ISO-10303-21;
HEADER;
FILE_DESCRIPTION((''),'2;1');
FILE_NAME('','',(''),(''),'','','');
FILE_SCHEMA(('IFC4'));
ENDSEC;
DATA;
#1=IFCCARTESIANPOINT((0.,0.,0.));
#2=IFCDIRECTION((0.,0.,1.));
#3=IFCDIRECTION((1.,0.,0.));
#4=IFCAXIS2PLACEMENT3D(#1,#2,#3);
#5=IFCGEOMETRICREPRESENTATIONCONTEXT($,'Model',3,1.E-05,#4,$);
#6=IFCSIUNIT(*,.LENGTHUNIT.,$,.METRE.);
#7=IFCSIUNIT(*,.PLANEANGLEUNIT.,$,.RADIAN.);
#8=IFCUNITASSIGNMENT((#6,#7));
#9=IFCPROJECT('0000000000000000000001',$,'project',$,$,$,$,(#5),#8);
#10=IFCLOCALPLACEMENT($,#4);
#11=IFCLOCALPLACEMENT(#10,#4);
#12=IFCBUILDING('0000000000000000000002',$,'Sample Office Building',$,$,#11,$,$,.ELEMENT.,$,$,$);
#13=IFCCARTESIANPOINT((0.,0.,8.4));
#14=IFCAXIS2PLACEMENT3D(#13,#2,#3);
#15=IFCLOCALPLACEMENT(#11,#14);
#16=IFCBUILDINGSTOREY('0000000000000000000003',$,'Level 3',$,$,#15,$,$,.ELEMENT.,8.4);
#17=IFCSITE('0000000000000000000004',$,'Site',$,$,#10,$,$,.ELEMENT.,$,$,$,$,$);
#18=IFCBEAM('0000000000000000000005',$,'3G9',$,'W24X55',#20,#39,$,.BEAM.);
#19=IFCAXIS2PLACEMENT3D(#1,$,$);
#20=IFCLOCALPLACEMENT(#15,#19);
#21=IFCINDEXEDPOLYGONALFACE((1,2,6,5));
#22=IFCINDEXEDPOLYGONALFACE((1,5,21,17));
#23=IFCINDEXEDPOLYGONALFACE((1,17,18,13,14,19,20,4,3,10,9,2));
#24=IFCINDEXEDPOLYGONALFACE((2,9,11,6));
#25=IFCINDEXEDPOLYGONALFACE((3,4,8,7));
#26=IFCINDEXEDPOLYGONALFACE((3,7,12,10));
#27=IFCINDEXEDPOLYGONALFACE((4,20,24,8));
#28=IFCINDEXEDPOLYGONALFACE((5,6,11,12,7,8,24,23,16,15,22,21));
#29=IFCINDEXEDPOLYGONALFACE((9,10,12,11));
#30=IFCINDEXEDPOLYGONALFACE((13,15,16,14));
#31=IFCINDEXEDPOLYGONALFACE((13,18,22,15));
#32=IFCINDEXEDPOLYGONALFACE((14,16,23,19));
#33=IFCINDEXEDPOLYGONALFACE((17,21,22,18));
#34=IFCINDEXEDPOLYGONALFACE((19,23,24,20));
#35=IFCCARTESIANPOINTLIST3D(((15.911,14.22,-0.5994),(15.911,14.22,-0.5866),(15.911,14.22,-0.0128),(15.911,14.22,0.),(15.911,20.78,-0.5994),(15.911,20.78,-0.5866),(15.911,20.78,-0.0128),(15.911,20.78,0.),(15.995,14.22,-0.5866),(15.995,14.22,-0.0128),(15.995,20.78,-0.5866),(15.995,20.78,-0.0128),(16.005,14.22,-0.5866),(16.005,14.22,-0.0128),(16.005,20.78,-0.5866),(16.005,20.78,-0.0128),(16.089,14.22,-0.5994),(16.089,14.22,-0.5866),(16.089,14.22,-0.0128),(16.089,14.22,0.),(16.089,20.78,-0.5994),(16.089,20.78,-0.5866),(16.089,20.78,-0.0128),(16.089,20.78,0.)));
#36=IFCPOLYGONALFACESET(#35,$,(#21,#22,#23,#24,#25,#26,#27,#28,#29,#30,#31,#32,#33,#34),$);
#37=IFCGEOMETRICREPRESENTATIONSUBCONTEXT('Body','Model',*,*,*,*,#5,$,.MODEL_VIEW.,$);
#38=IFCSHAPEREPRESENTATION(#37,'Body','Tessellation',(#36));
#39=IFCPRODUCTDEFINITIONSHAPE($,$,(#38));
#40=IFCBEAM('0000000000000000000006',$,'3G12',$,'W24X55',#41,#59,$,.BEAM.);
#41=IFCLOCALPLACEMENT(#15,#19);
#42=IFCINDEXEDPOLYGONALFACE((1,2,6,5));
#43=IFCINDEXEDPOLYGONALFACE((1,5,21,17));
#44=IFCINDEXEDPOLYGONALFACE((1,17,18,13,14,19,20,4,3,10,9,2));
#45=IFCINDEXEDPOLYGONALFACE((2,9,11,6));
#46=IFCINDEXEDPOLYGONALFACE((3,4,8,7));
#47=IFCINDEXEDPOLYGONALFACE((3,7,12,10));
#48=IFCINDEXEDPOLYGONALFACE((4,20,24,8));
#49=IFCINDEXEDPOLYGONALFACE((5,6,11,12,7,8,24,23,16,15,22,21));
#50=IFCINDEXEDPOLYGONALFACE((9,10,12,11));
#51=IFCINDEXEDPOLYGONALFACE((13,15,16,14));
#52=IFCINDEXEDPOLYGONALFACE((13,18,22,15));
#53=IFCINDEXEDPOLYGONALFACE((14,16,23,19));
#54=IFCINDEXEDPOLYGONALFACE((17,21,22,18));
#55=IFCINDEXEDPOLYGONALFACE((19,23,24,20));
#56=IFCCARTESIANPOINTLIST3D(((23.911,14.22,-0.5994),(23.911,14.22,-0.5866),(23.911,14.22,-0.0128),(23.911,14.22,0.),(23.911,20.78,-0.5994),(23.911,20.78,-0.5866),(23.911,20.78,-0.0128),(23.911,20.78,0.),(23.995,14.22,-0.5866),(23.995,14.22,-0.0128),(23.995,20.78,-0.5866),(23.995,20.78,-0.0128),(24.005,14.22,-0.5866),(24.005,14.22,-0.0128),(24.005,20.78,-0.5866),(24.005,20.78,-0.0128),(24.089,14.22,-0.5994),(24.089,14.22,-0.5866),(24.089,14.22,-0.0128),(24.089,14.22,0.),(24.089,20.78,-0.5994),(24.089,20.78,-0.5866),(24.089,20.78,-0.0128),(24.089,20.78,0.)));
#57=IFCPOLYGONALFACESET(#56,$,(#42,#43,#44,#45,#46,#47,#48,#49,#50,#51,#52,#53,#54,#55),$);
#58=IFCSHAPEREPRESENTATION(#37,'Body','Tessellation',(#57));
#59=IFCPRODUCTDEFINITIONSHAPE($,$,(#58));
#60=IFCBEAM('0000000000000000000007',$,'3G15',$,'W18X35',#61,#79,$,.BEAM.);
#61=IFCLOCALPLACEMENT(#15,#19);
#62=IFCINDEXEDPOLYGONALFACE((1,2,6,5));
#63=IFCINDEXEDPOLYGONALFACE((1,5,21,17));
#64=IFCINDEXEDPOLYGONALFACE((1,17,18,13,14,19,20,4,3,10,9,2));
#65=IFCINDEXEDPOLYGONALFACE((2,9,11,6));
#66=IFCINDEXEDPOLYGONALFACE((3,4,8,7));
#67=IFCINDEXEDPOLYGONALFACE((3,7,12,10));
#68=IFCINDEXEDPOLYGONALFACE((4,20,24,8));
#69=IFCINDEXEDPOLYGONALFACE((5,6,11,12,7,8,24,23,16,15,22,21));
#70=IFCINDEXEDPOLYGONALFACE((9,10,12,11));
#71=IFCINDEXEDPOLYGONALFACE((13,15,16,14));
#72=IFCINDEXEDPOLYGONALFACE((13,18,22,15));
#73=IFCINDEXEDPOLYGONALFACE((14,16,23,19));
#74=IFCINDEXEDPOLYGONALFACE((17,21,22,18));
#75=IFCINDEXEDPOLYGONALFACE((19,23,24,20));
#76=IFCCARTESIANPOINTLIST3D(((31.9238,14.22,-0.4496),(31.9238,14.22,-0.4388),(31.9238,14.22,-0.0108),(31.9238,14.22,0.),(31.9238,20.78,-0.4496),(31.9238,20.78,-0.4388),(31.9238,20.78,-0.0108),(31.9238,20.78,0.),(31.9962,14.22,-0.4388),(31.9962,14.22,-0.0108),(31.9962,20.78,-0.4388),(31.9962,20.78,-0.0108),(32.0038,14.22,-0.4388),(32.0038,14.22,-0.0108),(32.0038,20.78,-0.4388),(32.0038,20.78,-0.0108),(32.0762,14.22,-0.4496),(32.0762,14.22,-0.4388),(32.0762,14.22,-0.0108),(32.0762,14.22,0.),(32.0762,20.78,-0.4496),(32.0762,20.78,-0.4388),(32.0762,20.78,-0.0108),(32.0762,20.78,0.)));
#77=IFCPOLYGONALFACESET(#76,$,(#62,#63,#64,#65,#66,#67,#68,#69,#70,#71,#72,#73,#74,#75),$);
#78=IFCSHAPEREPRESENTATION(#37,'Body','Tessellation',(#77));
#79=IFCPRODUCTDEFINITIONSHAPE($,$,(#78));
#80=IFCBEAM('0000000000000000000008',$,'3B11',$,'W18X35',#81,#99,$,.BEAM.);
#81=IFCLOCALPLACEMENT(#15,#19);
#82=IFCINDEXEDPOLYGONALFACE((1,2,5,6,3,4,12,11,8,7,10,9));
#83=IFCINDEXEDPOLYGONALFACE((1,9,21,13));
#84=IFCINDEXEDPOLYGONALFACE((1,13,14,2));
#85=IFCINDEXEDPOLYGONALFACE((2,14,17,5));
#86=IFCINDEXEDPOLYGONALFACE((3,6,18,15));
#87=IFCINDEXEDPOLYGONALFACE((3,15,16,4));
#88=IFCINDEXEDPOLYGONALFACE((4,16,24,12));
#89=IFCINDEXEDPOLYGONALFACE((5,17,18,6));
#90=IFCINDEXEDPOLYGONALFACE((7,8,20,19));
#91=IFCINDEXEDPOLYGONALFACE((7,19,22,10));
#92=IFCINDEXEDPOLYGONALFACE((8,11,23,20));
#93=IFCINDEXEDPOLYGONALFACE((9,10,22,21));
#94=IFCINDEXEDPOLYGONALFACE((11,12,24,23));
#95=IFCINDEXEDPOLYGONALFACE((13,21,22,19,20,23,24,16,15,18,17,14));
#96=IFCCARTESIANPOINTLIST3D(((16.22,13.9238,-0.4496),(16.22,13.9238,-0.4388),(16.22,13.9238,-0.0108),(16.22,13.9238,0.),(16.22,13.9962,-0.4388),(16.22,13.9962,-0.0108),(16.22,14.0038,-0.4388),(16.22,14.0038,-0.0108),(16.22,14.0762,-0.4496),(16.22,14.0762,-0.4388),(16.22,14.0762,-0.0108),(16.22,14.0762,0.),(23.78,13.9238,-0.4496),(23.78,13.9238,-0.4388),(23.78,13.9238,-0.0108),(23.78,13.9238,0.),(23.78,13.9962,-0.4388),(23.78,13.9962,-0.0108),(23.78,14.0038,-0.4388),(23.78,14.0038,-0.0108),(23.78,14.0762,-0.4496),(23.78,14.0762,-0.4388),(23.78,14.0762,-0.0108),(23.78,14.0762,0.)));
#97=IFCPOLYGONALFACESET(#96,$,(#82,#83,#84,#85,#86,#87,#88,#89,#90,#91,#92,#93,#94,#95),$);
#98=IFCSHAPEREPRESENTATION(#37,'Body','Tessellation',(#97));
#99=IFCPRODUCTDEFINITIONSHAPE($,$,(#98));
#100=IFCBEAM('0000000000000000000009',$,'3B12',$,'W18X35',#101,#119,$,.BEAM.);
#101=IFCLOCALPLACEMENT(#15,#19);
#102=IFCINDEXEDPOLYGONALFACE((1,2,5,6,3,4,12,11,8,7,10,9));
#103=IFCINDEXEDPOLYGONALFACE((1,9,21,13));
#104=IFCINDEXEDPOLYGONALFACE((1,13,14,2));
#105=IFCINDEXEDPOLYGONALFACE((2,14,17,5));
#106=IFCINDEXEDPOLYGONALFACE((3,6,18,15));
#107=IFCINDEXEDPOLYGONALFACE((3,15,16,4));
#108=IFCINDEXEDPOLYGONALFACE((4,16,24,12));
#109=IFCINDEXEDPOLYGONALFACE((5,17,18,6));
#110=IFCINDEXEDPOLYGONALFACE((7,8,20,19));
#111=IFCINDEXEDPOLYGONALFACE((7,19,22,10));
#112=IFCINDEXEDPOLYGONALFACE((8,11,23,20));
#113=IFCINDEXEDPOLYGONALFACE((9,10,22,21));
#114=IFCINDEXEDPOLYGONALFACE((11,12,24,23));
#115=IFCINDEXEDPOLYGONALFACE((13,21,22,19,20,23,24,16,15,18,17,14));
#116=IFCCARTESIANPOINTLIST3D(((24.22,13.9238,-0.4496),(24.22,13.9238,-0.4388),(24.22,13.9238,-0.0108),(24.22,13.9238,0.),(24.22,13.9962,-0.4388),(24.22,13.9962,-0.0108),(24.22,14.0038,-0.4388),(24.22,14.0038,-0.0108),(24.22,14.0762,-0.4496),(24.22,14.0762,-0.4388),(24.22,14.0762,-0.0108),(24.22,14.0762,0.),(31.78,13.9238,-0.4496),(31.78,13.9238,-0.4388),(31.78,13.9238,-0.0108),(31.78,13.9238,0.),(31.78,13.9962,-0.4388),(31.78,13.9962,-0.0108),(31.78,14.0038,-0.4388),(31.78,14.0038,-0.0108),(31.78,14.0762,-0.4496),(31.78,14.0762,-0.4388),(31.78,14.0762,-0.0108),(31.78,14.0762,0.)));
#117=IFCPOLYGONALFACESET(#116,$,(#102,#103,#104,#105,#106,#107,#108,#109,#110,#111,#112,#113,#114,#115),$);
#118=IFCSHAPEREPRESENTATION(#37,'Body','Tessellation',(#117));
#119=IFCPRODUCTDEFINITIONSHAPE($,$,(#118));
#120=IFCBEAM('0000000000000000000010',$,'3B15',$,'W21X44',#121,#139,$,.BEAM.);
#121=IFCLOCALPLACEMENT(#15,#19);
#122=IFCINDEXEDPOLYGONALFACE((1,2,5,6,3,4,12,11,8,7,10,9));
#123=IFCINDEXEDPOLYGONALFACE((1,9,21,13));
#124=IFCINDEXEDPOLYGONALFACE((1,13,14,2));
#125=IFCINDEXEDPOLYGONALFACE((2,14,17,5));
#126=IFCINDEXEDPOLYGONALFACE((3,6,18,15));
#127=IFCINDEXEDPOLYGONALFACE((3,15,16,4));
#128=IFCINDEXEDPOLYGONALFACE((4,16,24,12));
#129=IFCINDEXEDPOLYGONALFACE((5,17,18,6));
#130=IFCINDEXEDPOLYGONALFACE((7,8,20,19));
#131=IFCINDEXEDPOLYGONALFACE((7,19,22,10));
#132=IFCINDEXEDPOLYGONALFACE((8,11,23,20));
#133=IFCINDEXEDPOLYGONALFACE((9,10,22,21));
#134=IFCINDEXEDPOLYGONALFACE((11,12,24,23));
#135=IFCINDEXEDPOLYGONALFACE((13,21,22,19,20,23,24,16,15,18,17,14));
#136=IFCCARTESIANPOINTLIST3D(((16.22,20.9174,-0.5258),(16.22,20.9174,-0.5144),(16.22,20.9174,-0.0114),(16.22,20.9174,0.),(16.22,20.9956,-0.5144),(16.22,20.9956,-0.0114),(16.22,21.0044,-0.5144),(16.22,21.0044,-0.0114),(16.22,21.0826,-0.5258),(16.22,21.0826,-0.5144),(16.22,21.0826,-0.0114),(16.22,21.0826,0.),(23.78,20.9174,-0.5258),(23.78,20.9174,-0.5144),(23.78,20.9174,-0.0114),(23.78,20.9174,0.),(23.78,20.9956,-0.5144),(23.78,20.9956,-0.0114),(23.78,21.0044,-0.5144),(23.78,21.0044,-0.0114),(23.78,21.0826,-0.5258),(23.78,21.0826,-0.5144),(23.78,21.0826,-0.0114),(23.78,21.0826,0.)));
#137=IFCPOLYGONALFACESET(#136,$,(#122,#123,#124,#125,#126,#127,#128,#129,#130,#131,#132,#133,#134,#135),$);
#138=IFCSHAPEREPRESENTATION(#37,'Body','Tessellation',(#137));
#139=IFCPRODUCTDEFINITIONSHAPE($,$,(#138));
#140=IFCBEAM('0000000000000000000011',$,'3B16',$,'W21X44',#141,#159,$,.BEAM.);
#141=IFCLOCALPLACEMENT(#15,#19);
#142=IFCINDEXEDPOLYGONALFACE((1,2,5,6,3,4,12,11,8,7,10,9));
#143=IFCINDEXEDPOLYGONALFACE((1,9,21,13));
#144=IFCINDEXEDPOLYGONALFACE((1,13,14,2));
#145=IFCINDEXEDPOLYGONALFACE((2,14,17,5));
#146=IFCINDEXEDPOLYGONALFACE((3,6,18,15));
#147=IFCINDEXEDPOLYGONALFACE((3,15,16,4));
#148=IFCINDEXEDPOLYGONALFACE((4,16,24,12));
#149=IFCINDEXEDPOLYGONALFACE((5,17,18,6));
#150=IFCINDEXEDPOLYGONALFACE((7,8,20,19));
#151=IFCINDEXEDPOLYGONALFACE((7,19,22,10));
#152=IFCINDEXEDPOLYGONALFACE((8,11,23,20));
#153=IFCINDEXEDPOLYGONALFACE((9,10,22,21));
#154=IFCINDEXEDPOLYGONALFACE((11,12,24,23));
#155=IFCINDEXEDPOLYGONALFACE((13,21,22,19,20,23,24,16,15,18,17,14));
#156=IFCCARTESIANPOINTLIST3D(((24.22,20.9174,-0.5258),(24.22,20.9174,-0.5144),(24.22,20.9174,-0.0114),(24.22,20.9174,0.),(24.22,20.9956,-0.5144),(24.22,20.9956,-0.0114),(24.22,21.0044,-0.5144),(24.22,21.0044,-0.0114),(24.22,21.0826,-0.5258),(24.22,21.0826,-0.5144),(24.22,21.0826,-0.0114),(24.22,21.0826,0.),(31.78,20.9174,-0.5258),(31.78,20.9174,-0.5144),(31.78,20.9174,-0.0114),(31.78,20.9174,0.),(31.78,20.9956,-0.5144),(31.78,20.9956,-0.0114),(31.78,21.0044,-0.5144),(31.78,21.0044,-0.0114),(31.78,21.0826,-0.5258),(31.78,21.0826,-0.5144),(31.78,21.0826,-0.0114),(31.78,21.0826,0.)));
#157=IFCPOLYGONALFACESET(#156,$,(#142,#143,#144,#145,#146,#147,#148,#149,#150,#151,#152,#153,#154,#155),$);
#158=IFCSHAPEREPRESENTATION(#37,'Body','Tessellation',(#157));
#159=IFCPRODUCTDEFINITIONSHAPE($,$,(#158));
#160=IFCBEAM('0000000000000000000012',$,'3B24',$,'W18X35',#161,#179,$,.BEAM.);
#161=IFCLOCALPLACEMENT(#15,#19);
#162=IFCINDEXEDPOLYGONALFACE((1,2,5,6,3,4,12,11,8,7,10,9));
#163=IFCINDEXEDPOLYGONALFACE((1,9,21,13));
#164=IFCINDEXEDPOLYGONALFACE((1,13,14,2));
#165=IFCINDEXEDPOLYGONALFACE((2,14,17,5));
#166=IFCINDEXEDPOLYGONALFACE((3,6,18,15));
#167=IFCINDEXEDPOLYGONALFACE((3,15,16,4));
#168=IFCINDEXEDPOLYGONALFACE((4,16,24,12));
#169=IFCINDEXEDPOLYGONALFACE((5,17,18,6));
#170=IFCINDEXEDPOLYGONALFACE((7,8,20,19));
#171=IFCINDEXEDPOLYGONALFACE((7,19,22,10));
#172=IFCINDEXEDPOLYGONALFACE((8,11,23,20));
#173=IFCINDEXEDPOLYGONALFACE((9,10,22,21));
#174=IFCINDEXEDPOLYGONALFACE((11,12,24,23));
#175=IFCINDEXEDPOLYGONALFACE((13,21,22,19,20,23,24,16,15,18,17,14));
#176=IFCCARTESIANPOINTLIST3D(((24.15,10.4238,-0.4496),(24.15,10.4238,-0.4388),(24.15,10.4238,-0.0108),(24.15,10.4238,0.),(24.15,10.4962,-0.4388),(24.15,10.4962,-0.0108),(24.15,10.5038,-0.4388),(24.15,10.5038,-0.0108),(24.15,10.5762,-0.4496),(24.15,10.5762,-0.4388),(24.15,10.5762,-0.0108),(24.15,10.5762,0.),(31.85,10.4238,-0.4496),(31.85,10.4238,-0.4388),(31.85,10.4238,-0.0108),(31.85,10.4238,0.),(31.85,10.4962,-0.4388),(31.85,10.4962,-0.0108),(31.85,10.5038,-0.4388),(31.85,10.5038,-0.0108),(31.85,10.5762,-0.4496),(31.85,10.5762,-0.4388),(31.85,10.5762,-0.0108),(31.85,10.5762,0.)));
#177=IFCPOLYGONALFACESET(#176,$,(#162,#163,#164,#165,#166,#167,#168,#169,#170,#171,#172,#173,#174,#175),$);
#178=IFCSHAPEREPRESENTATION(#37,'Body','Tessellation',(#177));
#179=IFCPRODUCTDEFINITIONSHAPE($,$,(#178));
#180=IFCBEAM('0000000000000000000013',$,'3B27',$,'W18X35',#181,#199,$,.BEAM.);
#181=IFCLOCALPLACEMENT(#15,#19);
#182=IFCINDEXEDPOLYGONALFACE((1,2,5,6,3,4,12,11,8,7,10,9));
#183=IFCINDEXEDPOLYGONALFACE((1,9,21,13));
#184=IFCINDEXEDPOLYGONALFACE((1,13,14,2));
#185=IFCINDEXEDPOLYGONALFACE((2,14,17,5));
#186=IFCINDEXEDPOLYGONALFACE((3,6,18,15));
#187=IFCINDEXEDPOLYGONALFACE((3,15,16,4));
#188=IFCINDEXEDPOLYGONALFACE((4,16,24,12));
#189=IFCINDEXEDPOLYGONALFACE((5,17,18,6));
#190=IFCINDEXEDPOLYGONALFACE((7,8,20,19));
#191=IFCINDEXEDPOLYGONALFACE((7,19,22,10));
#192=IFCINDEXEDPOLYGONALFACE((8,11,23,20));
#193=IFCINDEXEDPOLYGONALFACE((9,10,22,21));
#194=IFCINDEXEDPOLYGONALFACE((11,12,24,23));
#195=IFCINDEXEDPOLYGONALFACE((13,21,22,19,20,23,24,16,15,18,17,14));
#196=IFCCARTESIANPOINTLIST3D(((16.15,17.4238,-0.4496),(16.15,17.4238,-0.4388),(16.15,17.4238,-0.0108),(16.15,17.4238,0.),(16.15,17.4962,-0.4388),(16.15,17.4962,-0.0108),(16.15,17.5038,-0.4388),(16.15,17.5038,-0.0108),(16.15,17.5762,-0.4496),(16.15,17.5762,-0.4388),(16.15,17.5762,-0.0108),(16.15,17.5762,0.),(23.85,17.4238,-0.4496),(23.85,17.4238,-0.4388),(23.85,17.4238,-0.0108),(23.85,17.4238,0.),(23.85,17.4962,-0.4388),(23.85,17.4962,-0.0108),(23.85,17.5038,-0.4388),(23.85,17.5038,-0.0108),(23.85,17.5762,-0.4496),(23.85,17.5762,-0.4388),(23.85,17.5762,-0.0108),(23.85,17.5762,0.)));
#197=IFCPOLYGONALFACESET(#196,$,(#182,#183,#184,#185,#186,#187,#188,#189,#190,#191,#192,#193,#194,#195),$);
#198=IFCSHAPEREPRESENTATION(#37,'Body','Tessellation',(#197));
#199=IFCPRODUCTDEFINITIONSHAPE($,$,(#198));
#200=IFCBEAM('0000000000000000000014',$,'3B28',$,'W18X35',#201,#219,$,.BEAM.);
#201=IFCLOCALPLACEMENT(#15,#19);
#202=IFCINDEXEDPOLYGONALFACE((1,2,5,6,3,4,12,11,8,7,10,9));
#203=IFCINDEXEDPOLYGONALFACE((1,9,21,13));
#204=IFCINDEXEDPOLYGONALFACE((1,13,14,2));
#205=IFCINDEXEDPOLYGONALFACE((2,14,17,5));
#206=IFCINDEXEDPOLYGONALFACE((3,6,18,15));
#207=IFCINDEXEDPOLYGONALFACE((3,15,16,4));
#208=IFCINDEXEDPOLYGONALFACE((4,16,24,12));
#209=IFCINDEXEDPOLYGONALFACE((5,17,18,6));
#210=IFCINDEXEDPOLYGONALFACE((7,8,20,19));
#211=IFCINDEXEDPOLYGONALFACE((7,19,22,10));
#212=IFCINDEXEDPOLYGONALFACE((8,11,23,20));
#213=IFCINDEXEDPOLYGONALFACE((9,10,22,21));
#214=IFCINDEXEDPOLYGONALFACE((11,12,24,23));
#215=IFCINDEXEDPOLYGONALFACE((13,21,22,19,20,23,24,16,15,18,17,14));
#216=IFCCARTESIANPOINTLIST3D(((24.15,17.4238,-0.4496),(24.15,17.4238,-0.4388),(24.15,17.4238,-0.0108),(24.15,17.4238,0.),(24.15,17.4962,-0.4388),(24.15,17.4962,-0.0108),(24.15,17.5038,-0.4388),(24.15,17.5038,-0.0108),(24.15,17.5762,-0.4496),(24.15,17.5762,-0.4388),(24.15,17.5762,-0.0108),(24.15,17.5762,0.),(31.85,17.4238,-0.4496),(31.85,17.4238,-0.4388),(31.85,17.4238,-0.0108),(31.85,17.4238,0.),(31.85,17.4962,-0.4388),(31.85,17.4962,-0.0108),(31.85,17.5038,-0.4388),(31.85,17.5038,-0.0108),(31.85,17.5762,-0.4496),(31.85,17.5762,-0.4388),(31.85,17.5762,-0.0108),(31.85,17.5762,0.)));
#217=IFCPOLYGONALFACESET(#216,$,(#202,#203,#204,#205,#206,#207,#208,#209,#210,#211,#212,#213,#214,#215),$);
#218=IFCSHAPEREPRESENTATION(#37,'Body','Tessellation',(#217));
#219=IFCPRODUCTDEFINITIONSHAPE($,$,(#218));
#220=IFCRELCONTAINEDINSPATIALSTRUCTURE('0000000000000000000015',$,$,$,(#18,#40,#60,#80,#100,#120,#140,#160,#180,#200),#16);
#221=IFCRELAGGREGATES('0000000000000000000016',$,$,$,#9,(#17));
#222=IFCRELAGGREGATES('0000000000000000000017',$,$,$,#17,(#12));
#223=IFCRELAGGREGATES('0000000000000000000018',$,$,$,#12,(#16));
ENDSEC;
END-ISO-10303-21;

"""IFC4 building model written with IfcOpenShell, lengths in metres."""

from ifc_helpers import new_model, si_unit, frame, origin_with_axes, place, context, subcontext, project, spatial, i_section, extrude, element, save


model = new_model("IFC4")

# Units and contexts
model_context = context("Model", 3, precision=1e-05, world=origin_with_axes())
body_context = subcontext(model_context, "Body", "Model", "MODEL_VIEW")
ifc_project = project(units=[si_unit("LENGTHUNIT", "METRE"), si_unit("PLANEANGLEUNIT", "RADIAN")], contexts=[model_context])

# Site, building, storey
site_placement = place(None, origin_with_axes())
site = spatial("IfcSite", under=ifc_project, at=site_placement, Name="Site", CompositionType="ELEMENT")
building_placement = place(site_placement, origin_with_axes())
building = spatial("IfcBuilding", under=site, at=building_placement, Name="Sample Office Building", CompositionType="ELEMENT")
storey_placement = place(building_placement, frame((0.0, 0.0, 8.4), z_axis=(0.0, 0.0, 1.0), x_axis=(1.0, 0.0, 0.0)))
storey = spatial("IfcBuildingStorey", under=building, at=storey_placement, Name="Level 3", CompositionType="ELEMENT", Elevation=8.4)

# Beams
for number, where, z_axis, x_axis, name in (
    (1, (16.0, 14.22, 8.1003), (0.0, 1.0, 0.0), (-1.0, 0.0, 0.0), "3G9"),
    (2, (24.0, 14.22, 8.1003), (0.0, 1.0, 0.0), (-1.0, 0.0, 0.0), "3G12"),
):
    element("IfcBeam", number, at=place(None, frame(where, z_axis=z_axis, x_axis=x_axis)), inside=storey, Name=name, ObjectType="W24X55", PredefinedType="BEAM", context=body_context, shape_type="SweptSolid", body=[
        extrude(i_section(OverallWidth=0.1781, OverallDepth=0.5994, WebThickness=0.01, FlangeThickness=0.0128), None, (0.0, 0.0, 1.0), 6.56),
    ])
beam_placement = place(None, frame((32.0, 14.22, 8.1752), z_axis=(0.0, 1.0, 0.0), x_axis=(-1.0, 0.0, 0.0)))
element("IfcBeam", 3, at=beam_placement, inside=storey, Name="3G15", ObjectType="W18X35", PredefinedType="BEAM", context=body_context, shape_type="SweptSolid", body=[
    extrude(i_section(OverallWidth=0.1524, OverallDepth=0.4496, WebThickness=0.0076, FlangeThickness=0.0108), None, (0.0, 0.0, 1.0), 6.56),
])
for number, where, z_axis, x_axis, name in (
    (4, (16.22, 14.0, 8.1752), (1.0, 0.0, 0.0), (0.0, 1.0, 0.0), "3B11"),
    (5, (24.22, 14.0, 8.1752), (1.0, 0.0, 0.0), (0.0, 1.0, 0.0), "3B12"),
):
    element("IfcBeam", number, at=place(None, frame(where, z_axis=z_axis, x_axis=x_axis)), inside=storey, Name=name, ObjectType="W18X35", PredefinedType="BEAM", context=body_context, shape_type="SweptSolid", body=[
        extrude(i_section(OverallWidth=0.1524, OverallDepth=0.4496, WebThickness=0.0076, FlangeThickness=0.0108), None, (0.0, 0.0, 1.0), 7.56),
    ])
for number, where, z_axis, x_axis, name in (
    (6, (16.22, 21.0, 8.1371), (1.0, 0.0, 0.0), (0.0, 1.0, 0.0), "3B15"),
    (7, (24.22, 21.0, 8.1371), (1.0, 0.0, 0.0), (0.0, 1.0, 0.0), "3B16"),
):
    element("IfcBeam", number, at=place(None, frame(where, z_axis=z_axis, x_axis=x_axis)), inside=storey, Name=name, ObjectType="W21X44", PredefinedType="BEAM", context=body_context, shape_type="SweptSolid", body=[
        extrude(i_section(OverallWidth=0.1651, OverallDepth=0.5258, WebThickness=0.0089, FlangeThickness=0.0114), None, (0.0, 0.0, 1.0), 7.56),
    ])
for number, where, z_axis, x_axis, name in (
    (8, (24.15, 10.5, 8.1752), (1.0, 0.0, 0.0), (0.0, 1.0, 0.0), "3B24"),
    (9, (16.15, 17.5, 8.1752), (1.0, 0.0, 0.0), (0.0, 1.0, 0.0), "3B27"),
    (10, (24.15, 17.5, 8.1752), (1.0, 0.0, 0.0), (0.0, 1.0, 0.0), "3B28"),
):
    element("IfcBeam", number, at=place(None, frame(where, z_axis=z_axis, x_axis=x_axis)), inside=storey, Name=name, ObjectType="W18X35", PredefinedType="BEAM", context=body_context, shape_type="SweptSolid", body=[
        extrude(i_section(OverallWidth=0.1524, OverallDepth=0.4496, WebThickness=0.0076, FlangeThickness=0.0108), None, (0.0, 0.0, 1.0), 7.7),
    ])

save(model, "model.ifc")
